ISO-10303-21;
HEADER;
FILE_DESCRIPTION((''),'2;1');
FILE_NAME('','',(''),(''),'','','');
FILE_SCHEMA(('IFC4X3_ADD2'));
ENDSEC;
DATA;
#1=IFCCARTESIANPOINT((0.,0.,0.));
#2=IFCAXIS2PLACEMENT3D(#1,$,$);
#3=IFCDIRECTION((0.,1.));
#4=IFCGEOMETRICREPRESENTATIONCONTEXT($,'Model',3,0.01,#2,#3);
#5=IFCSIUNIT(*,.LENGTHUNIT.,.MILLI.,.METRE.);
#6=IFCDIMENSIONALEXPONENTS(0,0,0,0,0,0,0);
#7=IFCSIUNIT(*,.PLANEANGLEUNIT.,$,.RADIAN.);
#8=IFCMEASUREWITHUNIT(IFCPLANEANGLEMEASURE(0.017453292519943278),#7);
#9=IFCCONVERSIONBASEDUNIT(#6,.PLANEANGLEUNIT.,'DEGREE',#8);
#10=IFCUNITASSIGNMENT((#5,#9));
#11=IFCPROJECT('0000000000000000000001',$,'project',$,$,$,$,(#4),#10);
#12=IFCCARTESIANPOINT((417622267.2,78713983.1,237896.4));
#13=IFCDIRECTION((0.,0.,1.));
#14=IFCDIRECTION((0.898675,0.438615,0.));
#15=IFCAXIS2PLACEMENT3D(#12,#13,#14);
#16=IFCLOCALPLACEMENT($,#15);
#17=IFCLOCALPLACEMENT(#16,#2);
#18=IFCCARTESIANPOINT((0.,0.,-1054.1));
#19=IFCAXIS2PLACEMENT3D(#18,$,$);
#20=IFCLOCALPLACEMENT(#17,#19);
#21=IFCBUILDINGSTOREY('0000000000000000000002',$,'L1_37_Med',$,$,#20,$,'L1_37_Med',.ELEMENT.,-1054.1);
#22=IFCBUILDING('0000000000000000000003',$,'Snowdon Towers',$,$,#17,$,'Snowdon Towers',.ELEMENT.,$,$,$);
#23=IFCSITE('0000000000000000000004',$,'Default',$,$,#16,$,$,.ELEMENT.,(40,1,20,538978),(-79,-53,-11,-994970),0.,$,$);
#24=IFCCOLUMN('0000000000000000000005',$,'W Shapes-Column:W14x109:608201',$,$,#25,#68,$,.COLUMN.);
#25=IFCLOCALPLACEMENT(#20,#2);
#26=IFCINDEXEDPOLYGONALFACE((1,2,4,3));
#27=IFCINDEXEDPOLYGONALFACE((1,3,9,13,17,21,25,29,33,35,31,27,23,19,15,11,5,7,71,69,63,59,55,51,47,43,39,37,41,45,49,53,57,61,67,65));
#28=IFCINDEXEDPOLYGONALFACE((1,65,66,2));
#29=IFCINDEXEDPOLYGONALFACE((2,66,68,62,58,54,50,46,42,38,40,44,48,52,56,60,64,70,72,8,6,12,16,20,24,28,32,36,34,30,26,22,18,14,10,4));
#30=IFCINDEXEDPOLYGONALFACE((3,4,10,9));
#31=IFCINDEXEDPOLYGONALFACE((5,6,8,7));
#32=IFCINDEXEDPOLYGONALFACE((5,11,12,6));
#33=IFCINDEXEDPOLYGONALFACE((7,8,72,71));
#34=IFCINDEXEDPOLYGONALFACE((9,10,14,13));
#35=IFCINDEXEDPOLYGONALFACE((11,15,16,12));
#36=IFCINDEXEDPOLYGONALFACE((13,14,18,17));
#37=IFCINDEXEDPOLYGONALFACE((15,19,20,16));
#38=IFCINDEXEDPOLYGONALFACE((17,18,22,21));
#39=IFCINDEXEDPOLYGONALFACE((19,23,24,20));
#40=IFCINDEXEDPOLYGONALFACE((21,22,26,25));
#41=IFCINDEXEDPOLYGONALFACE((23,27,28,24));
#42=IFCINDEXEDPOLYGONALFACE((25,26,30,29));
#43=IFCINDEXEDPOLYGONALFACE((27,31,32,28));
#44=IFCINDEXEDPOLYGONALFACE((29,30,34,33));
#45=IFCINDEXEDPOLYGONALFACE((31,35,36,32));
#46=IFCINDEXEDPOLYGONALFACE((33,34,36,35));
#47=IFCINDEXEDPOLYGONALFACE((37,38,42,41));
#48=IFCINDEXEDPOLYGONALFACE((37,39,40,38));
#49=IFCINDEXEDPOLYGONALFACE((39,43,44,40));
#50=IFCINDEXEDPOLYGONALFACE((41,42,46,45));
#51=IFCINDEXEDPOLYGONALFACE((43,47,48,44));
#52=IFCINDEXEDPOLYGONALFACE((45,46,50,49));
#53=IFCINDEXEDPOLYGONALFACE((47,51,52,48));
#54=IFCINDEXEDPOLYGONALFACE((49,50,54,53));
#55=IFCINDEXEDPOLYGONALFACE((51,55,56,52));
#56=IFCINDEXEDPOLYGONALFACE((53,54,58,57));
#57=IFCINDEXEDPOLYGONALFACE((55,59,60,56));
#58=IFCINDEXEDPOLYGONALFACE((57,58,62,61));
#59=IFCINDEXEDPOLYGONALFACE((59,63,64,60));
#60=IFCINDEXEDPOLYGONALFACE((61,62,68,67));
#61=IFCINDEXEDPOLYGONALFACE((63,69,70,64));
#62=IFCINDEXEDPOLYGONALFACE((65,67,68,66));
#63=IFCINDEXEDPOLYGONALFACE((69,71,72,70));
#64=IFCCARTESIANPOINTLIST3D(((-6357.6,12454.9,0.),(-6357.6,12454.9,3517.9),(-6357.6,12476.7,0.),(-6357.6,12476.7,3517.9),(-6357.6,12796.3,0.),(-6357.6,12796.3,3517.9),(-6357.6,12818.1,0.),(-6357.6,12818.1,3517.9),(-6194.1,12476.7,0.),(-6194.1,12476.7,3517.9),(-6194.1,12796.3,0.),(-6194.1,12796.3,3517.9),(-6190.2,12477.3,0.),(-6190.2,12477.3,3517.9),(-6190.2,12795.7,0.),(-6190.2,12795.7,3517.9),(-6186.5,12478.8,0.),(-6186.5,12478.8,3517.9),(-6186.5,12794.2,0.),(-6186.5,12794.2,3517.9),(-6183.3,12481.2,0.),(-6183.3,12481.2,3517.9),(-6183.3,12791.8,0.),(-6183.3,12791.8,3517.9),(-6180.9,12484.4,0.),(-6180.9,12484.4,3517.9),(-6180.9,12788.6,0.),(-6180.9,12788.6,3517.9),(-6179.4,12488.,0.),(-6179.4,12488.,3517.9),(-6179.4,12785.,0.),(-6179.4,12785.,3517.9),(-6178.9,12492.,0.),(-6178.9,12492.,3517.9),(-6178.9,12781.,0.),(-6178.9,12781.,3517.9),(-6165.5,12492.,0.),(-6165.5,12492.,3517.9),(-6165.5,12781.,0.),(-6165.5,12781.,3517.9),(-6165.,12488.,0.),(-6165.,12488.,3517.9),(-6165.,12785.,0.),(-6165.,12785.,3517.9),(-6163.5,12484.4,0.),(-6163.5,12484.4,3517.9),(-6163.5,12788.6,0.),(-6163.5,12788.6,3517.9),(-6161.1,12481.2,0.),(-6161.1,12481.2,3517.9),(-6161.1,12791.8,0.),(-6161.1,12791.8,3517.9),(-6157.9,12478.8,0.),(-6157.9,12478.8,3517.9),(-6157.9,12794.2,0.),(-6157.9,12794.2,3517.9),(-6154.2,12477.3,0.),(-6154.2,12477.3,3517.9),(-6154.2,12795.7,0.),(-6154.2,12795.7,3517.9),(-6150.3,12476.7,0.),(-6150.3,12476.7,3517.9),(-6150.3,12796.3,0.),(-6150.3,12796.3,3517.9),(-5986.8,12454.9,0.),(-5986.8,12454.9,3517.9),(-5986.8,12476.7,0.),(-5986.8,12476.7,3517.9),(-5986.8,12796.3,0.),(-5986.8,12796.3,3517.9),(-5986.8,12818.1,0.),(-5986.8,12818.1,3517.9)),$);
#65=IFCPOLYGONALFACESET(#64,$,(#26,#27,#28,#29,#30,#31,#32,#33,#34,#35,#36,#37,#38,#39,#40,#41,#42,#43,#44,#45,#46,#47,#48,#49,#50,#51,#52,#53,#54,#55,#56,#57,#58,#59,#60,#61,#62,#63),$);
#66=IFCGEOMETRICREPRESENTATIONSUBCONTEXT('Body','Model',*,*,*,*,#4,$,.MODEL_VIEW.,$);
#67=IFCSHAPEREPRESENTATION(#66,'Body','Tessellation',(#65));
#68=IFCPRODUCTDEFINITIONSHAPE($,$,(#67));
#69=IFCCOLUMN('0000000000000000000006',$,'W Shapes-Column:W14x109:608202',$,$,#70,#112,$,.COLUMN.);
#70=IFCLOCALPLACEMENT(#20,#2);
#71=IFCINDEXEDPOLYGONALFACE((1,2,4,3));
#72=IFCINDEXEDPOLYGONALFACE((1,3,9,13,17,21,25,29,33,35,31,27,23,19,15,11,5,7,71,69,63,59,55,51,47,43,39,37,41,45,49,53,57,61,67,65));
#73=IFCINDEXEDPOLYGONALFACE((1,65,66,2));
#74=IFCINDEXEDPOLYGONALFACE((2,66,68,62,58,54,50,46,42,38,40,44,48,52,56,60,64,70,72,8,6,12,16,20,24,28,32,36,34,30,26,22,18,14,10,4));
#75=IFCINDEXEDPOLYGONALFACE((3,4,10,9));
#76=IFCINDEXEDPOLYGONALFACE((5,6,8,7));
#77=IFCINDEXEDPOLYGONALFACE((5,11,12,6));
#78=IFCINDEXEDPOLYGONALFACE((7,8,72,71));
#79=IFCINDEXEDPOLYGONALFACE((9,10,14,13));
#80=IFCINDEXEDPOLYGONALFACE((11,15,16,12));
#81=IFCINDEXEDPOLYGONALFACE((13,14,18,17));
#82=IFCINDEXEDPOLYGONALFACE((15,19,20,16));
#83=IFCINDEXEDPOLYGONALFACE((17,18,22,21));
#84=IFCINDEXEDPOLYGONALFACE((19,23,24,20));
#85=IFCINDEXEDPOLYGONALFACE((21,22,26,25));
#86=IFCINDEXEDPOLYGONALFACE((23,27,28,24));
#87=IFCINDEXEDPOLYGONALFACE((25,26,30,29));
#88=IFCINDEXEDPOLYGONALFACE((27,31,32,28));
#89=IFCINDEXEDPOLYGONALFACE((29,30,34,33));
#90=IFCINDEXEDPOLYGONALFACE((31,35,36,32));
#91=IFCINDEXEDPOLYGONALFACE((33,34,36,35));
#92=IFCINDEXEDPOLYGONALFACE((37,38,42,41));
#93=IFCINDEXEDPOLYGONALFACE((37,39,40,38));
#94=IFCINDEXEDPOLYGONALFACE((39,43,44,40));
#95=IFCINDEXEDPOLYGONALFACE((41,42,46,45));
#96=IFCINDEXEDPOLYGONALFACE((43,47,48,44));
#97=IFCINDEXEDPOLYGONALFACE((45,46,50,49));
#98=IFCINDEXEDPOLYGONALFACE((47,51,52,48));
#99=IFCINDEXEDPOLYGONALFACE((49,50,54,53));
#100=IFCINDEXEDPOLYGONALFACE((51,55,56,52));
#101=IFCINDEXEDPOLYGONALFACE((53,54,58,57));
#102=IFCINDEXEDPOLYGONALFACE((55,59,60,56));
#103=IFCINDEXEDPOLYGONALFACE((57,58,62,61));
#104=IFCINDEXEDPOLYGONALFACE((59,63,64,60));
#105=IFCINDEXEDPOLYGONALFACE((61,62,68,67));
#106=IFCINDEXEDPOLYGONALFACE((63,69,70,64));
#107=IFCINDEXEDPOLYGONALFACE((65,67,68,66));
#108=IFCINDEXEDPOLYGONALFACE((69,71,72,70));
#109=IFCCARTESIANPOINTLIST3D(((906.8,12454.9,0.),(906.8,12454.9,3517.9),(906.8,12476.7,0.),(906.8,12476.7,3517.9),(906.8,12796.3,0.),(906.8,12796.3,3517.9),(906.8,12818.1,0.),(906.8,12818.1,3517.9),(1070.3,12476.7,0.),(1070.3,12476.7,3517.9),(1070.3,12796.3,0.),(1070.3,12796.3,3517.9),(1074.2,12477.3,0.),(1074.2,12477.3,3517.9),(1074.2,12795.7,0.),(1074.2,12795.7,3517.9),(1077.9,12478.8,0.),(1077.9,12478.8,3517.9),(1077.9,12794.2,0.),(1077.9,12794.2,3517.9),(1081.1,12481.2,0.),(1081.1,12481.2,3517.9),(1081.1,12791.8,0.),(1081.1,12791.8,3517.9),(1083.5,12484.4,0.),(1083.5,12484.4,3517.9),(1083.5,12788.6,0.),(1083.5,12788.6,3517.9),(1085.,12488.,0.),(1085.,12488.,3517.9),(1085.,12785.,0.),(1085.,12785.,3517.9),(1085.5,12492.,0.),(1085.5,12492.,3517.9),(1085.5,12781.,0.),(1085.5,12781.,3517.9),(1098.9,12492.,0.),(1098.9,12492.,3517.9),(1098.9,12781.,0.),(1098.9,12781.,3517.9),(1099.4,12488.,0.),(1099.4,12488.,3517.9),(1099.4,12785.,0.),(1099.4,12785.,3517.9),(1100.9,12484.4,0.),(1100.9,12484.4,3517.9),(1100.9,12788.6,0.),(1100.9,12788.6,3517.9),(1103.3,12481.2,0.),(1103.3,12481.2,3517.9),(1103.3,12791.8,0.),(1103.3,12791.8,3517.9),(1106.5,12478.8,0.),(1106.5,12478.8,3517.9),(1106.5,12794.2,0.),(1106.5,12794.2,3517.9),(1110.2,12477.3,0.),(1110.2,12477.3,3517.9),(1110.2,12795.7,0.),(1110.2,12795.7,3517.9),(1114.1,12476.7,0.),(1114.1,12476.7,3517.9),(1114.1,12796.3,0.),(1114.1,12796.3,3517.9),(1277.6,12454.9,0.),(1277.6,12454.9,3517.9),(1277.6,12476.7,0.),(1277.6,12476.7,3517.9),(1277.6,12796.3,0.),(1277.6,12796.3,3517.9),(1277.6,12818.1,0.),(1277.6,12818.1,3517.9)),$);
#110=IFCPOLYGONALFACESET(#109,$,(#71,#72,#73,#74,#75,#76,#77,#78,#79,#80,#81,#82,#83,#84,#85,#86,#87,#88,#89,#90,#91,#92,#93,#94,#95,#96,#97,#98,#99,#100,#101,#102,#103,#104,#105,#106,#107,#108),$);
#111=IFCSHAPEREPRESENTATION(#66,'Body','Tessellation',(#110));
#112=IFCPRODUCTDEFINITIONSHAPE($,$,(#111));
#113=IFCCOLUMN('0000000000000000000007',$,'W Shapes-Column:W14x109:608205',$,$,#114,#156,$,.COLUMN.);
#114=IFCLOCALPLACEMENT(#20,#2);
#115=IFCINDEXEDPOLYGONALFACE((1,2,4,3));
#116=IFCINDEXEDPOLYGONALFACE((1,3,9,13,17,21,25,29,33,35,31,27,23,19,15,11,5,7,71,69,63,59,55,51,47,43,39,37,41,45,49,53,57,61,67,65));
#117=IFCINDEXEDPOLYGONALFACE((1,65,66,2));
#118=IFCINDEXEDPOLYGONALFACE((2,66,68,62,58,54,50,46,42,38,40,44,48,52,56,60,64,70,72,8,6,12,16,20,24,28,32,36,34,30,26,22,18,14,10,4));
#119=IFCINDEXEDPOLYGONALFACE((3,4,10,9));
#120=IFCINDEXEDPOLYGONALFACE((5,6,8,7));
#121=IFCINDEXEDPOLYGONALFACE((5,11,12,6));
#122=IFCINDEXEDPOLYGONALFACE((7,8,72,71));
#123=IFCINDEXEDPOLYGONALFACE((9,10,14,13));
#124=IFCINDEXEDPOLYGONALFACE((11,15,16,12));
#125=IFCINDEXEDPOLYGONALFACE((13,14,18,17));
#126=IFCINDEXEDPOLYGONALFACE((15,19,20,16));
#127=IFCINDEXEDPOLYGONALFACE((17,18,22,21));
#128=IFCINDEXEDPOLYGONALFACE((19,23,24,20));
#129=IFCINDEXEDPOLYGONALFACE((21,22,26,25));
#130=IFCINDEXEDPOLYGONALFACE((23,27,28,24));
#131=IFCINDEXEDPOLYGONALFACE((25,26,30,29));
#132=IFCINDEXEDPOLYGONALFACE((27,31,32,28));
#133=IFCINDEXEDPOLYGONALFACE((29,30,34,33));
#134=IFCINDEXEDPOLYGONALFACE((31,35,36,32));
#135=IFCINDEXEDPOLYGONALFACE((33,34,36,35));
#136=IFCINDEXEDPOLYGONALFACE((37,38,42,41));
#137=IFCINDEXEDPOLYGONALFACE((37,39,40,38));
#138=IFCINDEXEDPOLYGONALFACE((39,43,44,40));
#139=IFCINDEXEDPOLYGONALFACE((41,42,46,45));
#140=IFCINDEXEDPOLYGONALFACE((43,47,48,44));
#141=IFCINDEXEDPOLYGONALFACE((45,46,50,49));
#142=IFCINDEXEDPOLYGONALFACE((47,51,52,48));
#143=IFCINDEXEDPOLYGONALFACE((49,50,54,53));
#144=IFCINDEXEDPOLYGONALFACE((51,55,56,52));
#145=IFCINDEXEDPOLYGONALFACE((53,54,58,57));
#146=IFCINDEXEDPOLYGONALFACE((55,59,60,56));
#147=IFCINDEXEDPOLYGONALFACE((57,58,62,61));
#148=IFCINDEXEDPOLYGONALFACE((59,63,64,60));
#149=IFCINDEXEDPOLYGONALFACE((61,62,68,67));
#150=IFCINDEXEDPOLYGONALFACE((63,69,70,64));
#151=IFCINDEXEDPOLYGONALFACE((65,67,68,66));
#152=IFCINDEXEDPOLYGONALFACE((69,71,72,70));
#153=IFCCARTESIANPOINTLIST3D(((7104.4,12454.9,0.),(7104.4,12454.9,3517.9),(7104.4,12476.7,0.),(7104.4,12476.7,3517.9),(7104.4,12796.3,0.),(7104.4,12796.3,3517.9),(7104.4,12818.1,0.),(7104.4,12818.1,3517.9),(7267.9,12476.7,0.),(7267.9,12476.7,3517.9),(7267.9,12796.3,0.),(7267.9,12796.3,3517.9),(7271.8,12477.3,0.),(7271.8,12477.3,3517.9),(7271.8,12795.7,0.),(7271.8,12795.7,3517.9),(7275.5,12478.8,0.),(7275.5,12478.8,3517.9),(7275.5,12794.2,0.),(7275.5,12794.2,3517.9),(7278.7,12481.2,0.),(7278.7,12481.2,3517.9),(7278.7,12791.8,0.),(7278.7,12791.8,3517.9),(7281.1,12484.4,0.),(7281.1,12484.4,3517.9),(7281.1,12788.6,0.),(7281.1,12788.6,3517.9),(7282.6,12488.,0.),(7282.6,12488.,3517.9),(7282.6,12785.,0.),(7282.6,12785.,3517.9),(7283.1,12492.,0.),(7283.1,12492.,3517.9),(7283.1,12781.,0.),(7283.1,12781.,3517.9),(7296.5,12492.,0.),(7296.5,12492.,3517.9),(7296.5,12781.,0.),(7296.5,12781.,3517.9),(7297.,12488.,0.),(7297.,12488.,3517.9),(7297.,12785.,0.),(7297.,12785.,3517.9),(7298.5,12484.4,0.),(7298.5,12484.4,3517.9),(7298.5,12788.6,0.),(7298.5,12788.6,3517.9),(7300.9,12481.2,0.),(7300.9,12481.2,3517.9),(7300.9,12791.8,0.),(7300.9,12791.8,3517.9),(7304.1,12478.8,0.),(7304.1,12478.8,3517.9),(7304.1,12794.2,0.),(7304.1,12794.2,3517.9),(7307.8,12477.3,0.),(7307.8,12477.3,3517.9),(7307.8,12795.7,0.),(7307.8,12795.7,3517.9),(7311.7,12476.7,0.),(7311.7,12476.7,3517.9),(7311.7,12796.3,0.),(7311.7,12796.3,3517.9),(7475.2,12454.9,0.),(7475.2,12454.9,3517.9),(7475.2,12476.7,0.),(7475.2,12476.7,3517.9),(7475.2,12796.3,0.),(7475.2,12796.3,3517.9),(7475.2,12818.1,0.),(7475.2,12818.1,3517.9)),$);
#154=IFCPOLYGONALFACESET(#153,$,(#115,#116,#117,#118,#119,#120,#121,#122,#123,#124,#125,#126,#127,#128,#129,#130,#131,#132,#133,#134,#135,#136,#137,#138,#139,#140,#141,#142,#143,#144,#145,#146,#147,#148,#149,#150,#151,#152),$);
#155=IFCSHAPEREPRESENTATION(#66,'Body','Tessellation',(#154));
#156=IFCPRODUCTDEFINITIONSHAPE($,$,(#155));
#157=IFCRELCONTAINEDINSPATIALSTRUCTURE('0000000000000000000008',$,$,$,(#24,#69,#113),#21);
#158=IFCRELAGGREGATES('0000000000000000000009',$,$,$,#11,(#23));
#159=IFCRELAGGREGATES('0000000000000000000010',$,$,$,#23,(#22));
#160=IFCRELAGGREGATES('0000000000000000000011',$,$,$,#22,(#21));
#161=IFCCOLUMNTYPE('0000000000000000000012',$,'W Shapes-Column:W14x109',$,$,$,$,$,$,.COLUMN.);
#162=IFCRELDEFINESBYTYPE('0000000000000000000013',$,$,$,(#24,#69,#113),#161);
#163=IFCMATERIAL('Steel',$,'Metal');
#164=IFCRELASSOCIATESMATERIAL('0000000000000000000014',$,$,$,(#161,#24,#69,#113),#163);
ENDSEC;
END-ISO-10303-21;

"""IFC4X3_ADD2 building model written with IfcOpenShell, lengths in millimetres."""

from ifc_helpers import new_model, entity, si_unit, converted_unit, direction, frame, frame_2d, origin, place, context, subcontext, project, spatial, i_section, extrude, source, transform, mapped, material, material_profile, profile_set, profile_usage, type_object, type_shapes, element, save


model = new_model("IFC4X3_ADD2")

# Units and contexts
model_context = context("Model", 3, precision=0.01, world=origin(), true_north=direction((0.0, 1.0)))
body_context = subcontext(model_context, "Body", "Model", "MODEL_VIEW")
ifc_project = project(units=[si_unit("LENGTHUNIT", "METRE", prefix="MILLI"), converted_unit("PLANEANGLEUNIT", "DEGREE", entity("IfcPlaneAngleMeasure", 0.017453292519943278), si_unit("PLANEANGLEUNIT", "RADIAN"), dimensions=[0, 0, 0, 0, 0, 0, 0])], contexts=[model_context])

# Site, building, storey
site_placement = place(None, frame((417622267.2, 78713983.1, 237896.4), z_axis=(0.0, 0.0, 1.0), x_axis=(0.898675, 0.438615, 0.0)))
site = spatial("IfcSite", under=ifc_project, at=site_placement, Name="Default", CompositionType="ELEMENT", RefLatitude=(40, 1, 20, 538978), RefLongitude=(-79, -53, -11, -994970), RefElevation=0.0)
building_placement = place(site_placement, origin())
building = spatial("IfcBuilding", under=site, at=building_placement, Name="Snowdon Towers", LongName="Snowdon Towers", CompositionType="ELEMENT")
storey_placement = place(building_placement, frame((0.0, 0.0, -1054.1)))
storey = spatial("IfcBuildingStorey", under=building, at=storey_placement, Name="L1_37_Med", LongName="L1_37_Med", CompositionType="ELEMENT", Elevation=-1054.1)

# Columns
ifc_material_1 = material(Name="Steel", Category="Metal")
ifc_material_profile_1 = material_profile(ifc_material_1, i_section(OverallWidth=370.8, OverallDepth=363.2, WebThickness=13.3, FlangeThickness=21.8, FilletRadius=15.2, at=frame_2d((0.0, 0.0), x_axis=(1.0, 0.0))), Name="W14x109")
ifc_profile_set_1 = profile_set([ifc_material_profile_1], Name="W14x109")
ifc_profile_usage_1 = profile_usage(ifc_profile_set_1)
column_type_1 = type_object("IfcColumnType", Name="W Shapes-Column:W14x109", PredefinedType="COLUMN", material=ifc_profile_set_1)
shared_shape_1 = source(origin(), body_context, "Body", "SweptSolid", [
    extrude(i_section(OverallWidth=370.8, OverallDepth=363.2, WebThickness=13.3, FlangeThickness=21.8, FilletRadius=15.2, at=frame_2d((0.0, 0.0), x_axis=(1.0, 0.0))), frame((0.0, 0.0, -1054.1), z_axis=(0.0, 0.0, 1.0), x_axis=(-1.0, 0.0, 0.0)), (0.0, 0.0, 1.0), 3517.9),
])
type_shapes(column_type_1, [shared_shape_1])
for number, where, z_axis, x_axis, name in (
    (1, (-6172.2, 12636.5, 1054.1), (0.0, 0.0, 1.0), (-1.0, 0.0, 0.0), "W Shapes-Column:W14x109:608201"),
    (2, (1092.2, 12636.5, 1054.1), (0.0, 0.0, 1.0), (-1.0, 0.0, 0.0), "W Shapes-Column:W14x109:608202"),
):
    element("IfcColumn", number, at=place(storey_placement, frame(where, z_axis=z_axis, x_axis=x_axis)), inside=storey, type_object=column_type_1, material=ifc_profile_usage_1, Name=name, PredefinedType="COLUMN", context=body_context, shape_type="MappedRepresentation", body=[
        mapped(shared_shape_1, transform((0.0, 0.0, 0.0), scale=1.0)),
    ])
column_placement = place(storey_placement, frame((7289.8, 12636.5, 1054.1)))
element("IfcColumn", 3, at=column_placement, inside=storey, type_object=column_type_1, material=ifc_profile_usage_1, Name="W Shapes-Column:W14x109:608205", PredefinedType="COLUMN", context=body_context, shape_type="MappedRepresentation", body=[
    mapped(shared_shape_1, transform((0.0, 0.0, 0.0), scale=1.0)),
])

save(model, "model.ifc")
